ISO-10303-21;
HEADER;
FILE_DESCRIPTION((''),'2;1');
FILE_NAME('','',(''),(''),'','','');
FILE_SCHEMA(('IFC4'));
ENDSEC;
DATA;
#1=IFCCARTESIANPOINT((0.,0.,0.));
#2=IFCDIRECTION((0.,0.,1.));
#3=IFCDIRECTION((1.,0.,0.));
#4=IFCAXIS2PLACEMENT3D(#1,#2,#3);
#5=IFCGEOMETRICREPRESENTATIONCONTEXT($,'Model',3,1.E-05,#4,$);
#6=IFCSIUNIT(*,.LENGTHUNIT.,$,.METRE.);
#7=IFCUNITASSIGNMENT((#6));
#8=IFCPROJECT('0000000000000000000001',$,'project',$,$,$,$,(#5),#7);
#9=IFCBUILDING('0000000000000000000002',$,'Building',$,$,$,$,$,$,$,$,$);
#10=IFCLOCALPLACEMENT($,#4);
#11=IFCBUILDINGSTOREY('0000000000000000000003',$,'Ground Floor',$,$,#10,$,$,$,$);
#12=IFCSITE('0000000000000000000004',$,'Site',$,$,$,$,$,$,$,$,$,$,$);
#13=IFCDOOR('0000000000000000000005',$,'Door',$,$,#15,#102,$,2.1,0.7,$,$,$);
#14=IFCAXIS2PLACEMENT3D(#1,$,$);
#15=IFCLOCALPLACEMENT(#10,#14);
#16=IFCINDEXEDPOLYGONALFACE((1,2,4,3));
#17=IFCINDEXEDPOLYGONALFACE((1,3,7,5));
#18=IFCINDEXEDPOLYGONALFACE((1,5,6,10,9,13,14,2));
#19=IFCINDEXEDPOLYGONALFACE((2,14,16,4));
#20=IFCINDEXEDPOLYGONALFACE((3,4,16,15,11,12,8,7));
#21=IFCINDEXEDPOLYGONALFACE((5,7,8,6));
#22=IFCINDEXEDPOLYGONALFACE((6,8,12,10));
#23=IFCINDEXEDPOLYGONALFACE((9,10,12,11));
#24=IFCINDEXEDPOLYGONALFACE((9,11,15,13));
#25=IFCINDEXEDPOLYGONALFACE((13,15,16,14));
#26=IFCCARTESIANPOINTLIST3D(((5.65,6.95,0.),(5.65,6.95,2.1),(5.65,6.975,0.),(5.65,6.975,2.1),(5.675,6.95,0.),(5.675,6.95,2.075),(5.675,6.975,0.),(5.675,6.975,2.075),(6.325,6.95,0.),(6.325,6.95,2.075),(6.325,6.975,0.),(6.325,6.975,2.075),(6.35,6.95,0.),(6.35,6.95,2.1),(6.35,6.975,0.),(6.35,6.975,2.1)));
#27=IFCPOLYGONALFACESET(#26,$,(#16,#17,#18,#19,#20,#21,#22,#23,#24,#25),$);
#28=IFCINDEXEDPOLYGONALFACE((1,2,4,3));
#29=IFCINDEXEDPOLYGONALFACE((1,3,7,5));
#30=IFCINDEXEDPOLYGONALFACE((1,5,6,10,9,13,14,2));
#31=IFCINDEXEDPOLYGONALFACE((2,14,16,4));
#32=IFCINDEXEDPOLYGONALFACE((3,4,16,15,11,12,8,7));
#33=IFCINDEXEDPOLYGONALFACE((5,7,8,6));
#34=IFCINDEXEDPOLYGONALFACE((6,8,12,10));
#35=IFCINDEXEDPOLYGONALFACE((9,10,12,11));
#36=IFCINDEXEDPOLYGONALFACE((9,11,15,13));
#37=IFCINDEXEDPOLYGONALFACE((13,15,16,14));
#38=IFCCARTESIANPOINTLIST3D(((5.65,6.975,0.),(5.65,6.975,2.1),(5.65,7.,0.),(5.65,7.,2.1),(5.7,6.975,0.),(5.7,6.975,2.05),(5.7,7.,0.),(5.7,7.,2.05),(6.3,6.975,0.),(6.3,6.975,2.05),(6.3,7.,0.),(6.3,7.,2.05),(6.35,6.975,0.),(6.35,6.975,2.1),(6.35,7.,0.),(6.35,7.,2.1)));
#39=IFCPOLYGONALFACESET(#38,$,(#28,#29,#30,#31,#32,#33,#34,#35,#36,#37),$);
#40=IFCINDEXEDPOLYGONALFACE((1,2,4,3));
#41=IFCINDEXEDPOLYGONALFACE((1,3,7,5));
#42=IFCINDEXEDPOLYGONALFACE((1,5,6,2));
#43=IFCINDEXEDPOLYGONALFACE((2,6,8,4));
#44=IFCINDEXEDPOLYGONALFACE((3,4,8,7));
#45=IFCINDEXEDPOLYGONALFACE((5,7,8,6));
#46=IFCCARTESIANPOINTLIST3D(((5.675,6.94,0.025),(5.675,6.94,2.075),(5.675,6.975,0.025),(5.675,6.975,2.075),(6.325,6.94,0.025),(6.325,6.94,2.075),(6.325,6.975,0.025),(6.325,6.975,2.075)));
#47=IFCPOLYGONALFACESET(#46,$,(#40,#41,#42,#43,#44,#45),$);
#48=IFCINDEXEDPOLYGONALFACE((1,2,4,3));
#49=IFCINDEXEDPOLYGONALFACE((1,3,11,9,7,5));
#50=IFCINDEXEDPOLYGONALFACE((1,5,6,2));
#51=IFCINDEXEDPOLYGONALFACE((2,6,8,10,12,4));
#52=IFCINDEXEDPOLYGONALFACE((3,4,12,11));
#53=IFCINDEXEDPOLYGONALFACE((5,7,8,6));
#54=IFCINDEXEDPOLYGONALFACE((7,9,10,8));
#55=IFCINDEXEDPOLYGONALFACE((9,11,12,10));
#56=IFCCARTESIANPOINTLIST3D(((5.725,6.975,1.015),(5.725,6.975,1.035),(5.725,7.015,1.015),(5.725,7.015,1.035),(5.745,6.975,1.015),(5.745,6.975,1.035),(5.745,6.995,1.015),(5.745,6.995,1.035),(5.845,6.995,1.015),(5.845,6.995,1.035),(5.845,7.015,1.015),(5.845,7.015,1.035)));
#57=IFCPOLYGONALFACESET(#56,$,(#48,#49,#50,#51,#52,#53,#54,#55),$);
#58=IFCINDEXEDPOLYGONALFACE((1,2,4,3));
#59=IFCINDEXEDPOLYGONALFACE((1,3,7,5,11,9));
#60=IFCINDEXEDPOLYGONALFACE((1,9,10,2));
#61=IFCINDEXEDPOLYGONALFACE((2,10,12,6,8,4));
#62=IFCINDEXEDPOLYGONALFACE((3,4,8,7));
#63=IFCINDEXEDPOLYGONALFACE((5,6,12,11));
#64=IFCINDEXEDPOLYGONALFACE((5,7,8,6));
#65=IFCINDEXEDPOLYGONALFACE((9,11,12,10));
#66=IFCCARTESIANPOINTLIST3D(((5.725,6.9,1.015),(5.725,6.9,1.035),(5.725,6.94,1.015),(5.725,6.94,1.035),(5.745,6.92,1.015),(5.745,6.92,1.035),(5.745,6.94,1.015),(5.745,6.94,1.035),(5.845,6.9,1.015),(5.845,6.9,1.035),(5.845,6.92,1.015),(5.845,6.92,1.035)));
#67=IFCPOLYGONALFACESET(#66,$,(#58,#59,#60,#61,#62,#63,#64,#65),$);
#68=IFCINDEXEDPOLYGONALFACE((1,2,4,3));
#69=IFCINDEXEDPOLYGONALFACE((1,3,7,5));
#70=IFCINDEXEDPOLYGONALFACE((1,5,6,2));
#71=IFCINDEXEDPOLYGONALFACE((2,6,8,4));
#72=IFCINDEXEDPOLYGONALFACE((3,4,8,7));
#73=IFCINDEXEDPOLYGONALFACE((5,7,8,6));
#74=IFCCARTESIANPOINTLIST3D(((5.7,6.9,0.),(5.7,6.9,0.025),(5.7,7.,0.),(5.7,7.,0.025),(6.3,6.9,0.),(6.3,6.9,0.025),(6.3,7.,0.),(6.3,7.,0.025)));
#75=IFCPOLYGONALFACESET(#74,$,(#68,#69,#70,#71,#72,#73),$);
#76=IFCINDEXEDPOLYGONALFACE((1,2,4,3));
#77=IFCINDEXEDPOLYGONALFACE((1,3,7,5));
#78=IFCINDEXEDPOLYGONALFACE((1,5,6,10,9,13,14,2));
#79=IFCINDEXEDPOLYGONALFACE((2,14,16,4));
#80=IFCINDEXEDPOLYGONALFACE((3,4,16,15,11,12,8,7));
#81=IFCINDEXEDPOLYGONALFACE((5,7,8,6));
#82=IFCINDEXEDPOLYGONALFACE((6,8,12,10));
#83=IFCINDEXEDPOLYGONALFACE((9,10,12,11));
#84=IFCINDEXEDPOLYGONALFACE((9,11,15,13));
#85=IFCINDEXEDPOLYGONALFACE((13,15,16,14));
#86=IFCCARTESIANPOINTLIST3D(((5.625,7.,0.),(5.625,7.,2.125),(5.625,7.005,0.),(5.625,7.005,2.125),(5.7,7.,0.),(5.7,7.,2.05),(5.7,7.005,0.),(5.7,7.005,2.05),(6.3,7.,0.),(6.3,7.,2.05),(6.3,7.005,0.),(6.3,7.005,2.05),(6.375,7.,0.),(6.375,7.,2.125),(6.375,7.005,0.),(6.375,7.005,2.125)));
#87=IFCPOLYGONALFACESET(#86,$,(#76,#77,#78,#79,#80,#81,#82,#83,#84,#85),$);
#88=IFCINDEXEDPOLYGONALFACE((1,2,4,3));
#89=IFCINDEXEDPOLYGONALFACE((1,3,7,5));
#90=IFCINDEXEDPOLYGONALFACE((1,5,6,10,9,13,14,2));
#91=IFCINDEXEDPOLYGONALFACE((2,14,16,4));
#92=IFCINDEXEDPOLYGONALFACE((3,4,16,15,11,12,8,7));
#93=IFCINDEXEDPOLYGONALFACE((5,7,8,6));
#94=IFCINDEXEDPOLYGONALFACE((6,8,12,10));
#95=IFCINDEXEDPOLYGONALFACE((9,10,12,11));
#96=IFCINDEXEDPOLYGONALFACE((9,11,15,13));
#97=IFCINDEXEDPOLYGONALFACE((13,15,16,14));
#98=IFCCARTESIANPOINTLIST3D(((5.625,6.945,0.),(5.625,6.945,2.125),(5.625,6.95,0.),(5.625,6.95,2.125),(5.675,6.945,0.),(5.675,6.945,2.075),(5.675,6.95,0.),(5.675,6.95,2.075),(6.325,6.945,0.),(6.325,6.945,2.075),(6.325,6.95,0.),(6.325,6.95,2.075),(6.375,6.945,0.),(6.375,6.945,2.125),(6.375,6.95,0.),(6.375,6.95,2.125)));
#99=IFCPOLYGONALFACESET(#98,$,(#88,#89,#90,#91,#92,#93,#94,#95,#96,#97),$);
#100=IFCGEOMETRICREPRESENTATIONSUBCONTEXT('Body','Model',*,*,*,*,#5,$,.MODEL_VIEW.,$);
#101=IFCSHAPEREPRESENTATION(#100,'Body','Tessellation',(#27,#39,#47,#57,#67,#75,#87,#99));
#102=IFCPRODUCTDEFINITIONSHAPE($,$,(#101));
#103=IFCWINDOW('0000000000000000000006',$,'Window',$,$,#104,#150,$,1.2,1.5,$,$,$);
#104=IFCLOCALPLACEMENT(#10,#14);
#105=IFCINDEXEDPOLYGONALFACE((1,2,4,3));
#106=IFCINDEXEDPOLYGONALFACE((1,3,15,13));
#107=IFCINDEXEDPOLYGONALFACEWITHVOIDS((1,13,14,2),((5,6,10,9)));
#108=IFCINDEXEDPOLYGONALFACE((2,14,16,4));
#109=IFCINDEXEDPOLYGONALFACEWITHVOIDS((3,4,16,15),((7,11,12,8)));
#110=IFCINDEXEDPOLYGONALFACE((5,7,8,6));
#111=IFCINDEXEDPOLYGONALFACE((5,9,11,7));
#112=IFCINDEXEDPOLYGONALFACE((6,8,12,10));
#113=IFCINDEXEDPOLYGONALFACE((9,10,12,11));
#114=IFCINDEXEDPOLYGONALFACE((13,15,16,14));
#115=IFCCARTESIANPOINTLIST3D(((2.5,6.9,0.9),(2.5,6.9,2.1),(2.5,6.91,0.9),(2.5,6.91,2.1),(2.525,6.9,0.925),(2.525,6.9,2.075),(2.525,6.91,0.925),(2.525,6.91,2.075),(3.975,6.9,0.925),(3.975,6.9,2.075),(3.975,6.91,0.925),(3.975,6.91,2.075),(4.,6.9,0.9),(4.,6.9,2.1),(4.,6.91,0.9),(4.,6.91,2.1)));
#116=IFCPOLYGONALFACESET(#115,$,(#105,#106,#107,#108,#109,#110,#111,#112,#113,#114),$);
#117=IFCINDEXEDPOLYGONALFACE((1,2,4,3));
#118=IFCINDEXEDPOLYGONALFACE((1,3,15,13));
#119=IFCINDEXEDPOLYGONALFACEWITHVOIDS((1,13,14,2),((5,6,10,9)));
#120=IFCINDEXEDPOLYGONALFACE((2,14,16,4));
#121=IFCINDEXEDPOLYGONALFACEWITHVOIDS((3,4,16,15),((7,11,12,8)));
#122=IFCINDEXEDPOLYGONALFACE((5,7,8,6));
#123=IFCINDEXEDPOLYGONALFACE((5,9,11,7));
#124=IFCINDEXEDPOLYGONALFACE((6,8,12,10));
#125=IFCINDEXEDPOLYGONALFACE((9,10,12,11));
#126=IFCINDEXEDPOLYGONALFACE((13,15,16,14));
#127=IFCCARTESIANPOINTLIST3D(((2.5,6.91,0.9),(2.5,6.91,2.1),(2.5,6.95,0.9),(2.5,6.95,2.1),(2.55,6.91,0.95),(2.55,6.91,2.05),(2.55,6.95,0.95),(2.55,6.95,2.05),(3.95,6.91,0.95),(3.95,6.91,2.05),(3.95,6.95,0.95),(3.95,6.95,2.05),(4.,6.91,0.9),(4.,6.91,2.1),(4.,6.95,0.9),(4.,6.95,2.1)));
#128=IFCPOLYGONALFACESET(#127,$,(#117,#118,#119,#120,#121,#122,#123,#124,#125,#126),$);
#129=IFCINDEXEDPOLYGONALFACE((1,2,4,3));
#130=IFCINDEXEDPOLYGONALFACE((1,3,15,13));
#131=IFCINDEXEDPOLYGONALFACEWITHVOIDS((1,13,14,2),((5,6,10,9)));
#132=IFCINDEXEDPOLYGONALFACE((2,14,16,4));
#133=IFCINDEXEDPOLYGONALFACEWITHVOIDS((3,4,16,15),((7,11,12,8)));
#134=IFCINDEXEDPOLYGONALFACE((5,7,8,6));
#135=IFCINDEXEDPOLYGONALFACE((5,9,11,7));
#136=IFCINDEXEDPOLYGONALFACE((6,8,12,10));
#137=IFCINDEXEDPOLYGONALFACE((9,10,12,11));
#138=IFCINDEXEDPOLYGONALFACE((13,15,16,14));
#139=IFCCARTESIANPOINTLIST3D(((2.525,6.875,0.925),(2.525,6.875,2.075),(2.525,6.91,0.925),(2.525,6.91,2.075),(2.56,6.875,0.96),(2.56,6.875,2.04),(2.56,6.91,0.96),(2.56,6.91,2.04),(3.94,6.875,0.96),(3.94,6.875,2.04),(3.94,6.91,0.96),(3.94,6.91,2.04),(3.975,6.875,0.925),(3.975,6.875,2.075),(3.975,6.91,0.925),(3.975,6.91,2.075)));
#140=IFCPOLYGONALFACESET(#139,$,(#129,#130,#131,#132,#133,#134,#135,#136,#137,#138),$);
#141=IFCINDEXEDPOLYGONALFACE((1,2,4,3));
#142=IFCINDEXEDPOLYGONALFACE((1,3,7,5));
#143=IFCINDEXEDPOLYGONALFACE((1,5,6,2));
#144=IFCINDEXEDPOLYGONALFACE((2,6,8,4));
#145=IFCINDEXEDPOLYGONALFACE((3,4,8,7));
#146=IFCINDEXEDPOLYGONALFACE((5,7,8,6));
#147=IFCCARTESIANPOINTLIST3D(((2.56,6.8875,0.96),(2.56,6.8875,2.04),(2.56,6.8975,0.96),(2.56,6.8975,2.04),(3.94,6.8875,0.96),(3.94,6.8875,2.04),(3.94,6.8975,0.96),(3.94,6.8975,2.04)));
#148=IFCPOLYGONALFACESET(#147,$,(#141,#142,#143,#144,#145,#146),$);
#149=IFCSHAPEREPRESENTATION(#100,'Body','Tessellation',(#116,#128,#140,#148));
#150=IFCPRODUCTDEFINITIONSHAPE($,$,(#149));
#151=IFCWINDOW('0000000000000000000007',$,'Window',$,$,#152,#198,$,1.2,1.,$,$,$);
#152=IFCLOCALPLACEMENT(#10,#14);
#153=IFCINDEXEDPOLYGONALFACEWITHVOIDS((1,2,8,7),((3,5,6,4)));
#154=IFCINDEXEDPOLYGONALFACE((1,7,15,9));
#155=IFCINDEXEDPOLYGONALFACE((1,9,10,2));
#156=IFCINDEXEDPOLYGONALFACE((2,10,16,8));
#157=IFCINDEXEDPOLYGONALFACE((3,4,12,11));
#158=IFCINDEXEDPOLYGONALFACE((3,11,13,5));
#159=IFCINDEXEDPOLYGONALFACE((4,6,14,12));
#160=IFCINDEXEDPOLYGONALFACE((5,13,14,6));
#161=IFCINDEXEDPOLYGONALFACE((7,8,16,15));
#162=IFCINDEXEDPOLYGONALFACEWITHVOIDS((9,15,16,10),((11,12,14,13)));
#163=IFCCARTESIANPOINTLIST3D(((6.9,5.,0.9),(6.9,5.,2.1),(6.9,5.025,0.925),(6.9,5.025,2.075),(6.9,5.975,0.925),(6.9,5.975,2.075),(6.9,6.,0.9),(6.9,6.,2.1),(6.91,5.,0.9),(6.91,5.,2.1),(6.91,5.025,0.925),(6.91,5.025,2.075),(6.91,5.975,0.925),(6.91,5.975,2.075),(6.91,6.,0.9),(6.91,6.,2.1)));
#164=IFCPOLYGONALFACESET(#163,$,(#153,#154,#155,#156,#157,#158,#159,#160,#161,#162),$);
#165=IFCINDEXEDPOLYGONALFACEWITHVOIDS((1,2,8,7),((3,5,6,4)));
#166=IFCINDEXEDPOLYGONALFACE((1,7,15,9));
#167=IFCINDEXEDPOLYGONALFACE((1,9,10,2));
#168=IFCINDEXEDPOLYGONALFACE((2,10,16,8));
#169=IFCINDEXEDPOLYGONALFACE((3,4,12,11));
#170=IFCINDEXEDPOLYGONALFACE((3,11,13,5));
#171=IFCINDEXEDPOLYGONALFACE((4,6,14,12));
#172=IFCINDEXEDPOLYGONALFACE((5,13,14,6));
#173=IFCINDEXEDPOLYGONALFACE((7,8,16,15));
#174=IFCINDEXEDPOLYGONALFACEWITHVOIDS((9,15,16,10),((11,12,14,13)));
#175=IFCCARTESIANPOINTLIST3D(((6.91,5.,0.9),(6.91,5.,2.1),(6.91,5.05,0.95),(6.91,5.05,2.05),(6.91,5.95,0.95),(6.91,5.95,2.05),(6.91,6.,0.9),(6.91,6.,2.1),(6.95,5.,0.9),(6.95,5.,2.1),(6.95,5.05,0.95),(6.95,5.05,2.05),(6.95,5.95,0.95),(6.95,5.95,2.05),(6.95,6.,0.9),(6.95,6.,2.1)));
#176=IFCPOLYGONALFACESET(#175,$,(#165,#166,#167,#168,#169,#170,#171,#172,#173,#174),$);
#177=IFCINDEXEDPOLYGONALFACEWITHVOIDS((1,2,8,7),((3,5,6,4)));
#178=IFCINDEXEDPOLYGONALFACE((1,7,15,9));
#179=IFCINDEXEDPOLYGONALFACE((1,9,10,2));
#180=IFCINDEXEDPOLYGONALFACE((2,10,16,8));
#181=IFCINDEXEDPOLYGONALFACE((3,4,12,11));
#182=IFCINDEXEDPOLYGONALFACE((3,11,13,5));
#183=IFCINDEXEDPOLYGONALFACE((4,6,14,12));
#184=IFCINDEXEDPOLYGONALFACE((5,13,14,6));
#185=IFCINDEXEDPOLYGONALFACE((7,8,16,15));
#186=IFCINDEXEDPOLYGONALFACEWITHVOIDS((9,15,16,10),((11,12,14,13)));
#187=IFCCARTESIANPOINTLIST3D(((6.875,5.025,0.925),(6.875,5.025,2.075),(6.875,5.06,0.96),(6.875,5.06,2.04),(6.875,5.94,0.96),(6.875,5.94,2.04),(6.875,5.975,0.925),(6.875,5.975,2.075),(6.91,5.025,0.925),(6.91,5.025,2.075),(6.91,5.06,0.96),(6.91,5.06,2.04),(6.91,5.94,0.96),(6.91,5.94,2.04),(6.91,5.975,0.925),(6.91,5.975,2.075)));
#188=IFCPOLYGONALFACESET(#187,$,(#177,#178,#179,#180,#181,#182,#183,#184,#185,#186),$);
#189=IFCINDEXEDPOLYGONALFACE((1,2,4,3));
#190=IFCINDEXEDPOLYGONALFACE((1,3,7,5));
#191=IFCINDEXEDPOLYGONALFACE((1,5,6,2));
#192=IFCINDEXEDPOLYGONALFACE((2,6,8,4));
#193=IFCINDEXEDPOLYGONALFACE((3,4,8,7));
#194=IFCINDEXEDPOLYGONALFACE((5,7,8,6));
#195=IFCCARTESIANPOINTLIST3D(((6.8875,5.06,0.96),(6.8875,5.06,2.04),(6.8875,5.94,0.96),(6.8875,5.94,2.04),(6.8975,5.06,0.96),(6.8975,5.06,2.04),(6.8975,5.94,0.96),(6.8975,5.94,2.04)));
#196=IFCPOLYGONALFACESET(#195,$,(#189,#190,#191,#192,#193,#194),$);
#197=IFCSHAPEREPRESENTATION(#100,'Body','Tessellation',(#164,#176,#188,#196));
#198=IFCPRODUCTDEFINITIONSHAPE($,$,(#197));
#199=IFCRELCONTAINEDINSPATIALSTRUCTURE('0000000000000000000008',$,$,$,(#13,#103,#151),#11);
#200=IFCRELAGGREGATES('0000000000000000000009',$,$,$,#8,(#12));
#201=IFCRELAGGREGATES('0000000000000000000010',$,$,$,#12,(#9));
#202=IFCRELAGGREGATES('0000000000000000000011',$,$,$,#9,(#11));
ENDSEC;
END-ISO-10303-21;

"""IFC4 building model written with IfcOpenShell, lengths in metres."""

from ifc_helpers import new_model, si_unit, frame, origin_with_axes, place, context, subcontext, project, spatial, line, indexed_curve, outline, extrude, element, save


model = new_model("IFC4")

# Units and contexts
model_context = context("Model", 3, precision=1e-05, world=origin_with_axes())
body_context = subcontext(model_context, "Body", "Model", "MODEL_VIEW")
ifc_project = project(units=[si_unit("LENGTHUNIT", "METRE")], contexts=[model_context])

# Site, building, storey
site = spatial("IfcSite", under=ifc_project, Name="Site")
building = spatial("IfcBuilding", under=site, Name="Building")
storey_placement = place(None, origin_with_axes())
storey = spatial("IfcBuildingStorey", under=building, at=storey_placement, Name="Ground Floor")

# Door
door_1_placement = place(storey_placement, frame((6.35, 7.0, 0.0), z_axis=(0.0, 0.0, 1.0), x_axis=(-1.0, 0.0, 0.0)))
element("IfcDoor", 1, at=door_1_placement, inside=storey, Name="Door", OverallHeight=2.1, OverallWidth=0.7, context=body_context, shape_type="SweptSolid", body=[
    extrude(outline(indexed_curve([(0.0, 0.0), (0.0, 2.1), (0.7, 2.1), (0.7, 0.0), (0.675, 0.0), (0.675, 2.075), (0.025, 2.075), (0.025, 0.0)], segments=[line(1, 2, 3, 4, 5, 6, 7, 8, 1)])), frame((0.0, 0.025, 0.0), z_axis=(0.0, -1.0, 0.0), x_axis=(1.0, 0.0, 0.0)), (0.0, 0.0, -1.0), 0.025),
    extrude(outline(indexed_curve([(0.0, 0.0), (0.0, 2.1), (0.7, 2.1), (0.7, 0.0), (0.65, 0.0), (0.65, 2.05), (0.05, 2.05), (0.05, 0.0)], segments=[line(1, 2, 3, 4, 5, 6, 7, 8, 1)])), frame((0.0, 0.0, 0.0), z_axis=(0.0, -1.0, 0.0), x_axis=(1.0, 0.0, 0.0)), (0.0, 0.0, -1.0), 0.025),
    extrude(outline(indexed_curve([(0.0, 0.0), (0.65, 0.0), (0.65, 0.035), (0.0, 0.035)], segments=[line(1, 2, 3, 4, 1)])), frame((0.025, 0.025, 0.025), z_axis=(0.0, 0.0, 1.0), x_axis=(1.0, 0.0, 0.0)), (0.0, 0.0, 1.0), 2.05),
    extrude(outline(indexed_curve([(0.0, 0.0), (0.0, -0.04), (-0.12, -0.04), (-0.12, -0.02), (-0.02, -0.02), (-0.02, 0.0)], segments=[line(1, 2, 3, 4, 5, 6, 1)])), frame((0.625, 0.025, 1.015), z_axis=(0.0, 0.0, 1.0), x_axis=(1.0, 0.0, 0.0)), (0.0, 0.0, 1.0), 0.02),
    extrude(outline(indexed_curve([(0.0, 0.0), (0.0, 0.04), (-0.12, 0.04), (-0.12, 0.02), (-0.02, 0.02), (-0.02, 0.0)], segments=[line(1, 2, 3, 4, 5, 6, 1)])), frame((0.625, 0.06, 1.015), z_axis=(0.0, 0.0, 1.0), x_axis=(1.0, 0.0, 0.0)), (0.0, 0.0, 1.0), 0.02),
    extrude(outline(indexed_curve([(0.0, 0.0), (0.6, 0.0), (0.6, 0.1), (0.0, 0.1)], segments=[line(1, 2, 3, 4, 1)])), frame((0.05, 0.0, 0.0), z_axis=(0.0, 0.0, 1.0), x_axis=(1.0, 0.0, 0.0)), (0.0, 0.0, 1.0), 0.025),
    extrude(outline(indexed_curve([(0.0, 0.0), (0.0, 2.125), (0.75, 2.125), (0.75, 0.0), (0.675, 0.0), (0.675, 2.05), (0.075, 2.05), (0.075, 0.0)], segments=[line(1, 2, 3, 4, 5, 6, 7, 8, 1)])), frame((-0.025, -0.005, 0.0), z_axis=(0.0, -1.0, 0.0), x_axis=(1.0, 0.0, 0.0)), (0.0, 0.0, -1.0), 0.005),
    extrude(outline(indexed_curve([(0.0, 0.0), (0.0, 2.125), (0.75, 2.125), (0.75, 0.0), (0.7, 0.0), (0.7, 2.075), (0.05, 2.075), (0.05, 0.0)], segments=[line(1, 2, 3, 4, 5, 6, 7, 8, 1)])), frame((-0.025, 0.05, 0.0), z_axis=(0.0, -1.0, 0.0), x_axis=(1.0, 0.0, 0.0)), (0.0, 0.0, -1.0), 0.005),
])

# Windows
window_1_placement = place(storey_placement, frame((4.0, 7.0, 0.9), z_axis=(0.0, 0.0, 1.0), x_axis=(-1.0, 0.0, 0.0)))
element("IfcWindow", 2, at=window_1_placement, inside=storey, Name="Window", OverallHeight=1.2, OverallWidth=1.5, context=body_context, shape_type="SweptSolid", body=[
    extrude(outline(indexed_curve([(0.0, 0.0), (1.5, 0.0), (1.5, 1.2), (0.0, 1.2)], segments=[line(1, 2, 3, 4, 1)]), holes=[indexed_curve([(0.025, 0.025), (1.475, 0.025), (1.475, 1.175), (0.025, 1.175)], segments=[line(1, 2, 3, 4, 1)])]), frame((0.0, 0.09, 0.0), z_axis=(0.0, -1.0, 0.0), x_axis=(1.0, 0.0, 0.0)), (0.0, 0.0, -1.0), 0.01),
    extrude(outline(indexed_curve([(0.0, 0.0), (1.5, 0.0), (1.5, 1.2), (0.0, 1.2)], segments=[line(1, 2, 3, 4, 1)]), holes=[indexed_curve([(0.05, 0.05), (1.45, 0.05), (1.45, 1.15), (0.05, 1.15)], segments=[line(1, 2, 3, 4, 1)])]), frame((0.0, 0.05, 0.0), z_axis=(0.0, -1.0, 0.0), x_axis=(1.0, 0.0, 0.0)), (0.0, 0.0, -1.0), 0.04),
    extrude(outline(indexed_curve([(0.0, 0.0), (1.45, 0.0), (1.45, 1.15), (0.0, 1.15)], segments=[line(1, 2, 3, 4, 1)]), holes=[indexed_curve([(0.035, 0.035), (1.415, 0.035), (1.415, 1.115), (0.035, 1.115)], segments=[line(1, 2, 3, 4, 1)])]), frame((0.025, 0.09, 0.025), z_axis=(0.0, -1.0, 0.0), x_axis=(1.0, 0.0, 0.0)), (0.0, 0.0, -1.0), 0.035),
    extrude(outline(indexed_curve([(0.035, 0.035), (1.415, 0.035), (1.415, 1.115), (0.035, 1.115)], segments=[line(1, 2, 3, 4, 1)])), frame((0.025, 0.1025, 0.025), z_axis=(0.0, -1.0, 0.0), x_axis=(1.0, 0.0, 0.0)), (0.0, 0.0, -1.0), 0.01),
])
window_2_placement = place(storey_placement, frame((7.0, 5.0, 0.9), z_axis=(0.0, 0.0, 1.0), x_axis=(0.0, 1.0, 0.0)))
element("IfcWindow", 3, at=window_2_placement, inside=storey, Name="Window", OverallHeight=1.2, OverallWidth=1.0, context=body_context, shape_type="SweptSolid", body=[
    extrude(outline(indexed_curve([(0.0, 0.0), (1.0, 0.0), (1.0, 1.2), (0.0, 1.2)], segments=[line(1, 2, 3, 4, 1)]), holes=[indexed_curve([(0.025, 0.025), (0.975, 0.025), (0.975, 1.175), (0.025, 1.175)], segments=[line(1, 2, 3, 4, 1)])]), frame((0.0, 0.09, 0.0), z_axis=(0.0, -1.0, 0.0), x_axis=(1.0, 0.0, 0.0)), (0.0, 0.0, -1.0), 0.01),
    extrude(outline(indexed_curve([(0.0, 0.0), (1.0, 0.0), (1.0, 1.2), (0.0, 1.2)], segments=[line(1, 2, 3, 4, 1)]), holes=[indexed_curve([(0.05, 0.05), (0.95, 0.05), (0.95, 1.15), (0.05, 1.15)], segments=[line(1, 2, 3, 4, 1)])]), frame((0.0, 0.05, 0.0), z_axis=(0.0, -1.0, 0.0), x_axis=(1.0, 0.0, 0.0)), (0.0, 0.0, -1.0), 0.04),
    extrude(outline(indexed_curve([(0.0, 0.0), (0.95, 0.0), (0.95, 1.15), (0.0, 1.15)], segments=[line(1, 2, 3, 4, 1)]), holes=[indexed_curve([(0.035, 0.035), (0.915, 0.035), (0.915, 1.115), (0.035, 1.115)], segments=[line(1, 2, 3, 4, 1)])]), frame((0.025, 0.09, 0.025), z_axis=(0.0, -1.0, 0.0), x_axis=(1.0, 0.0, 0.0)), (0.0, 0.0, -1.0), 0.035),
    extrude(outline(indexed_curve([(0.035, 0.035), (0.915, 0.035), (0.915, 1.115), (0.035, 1.115)], segments=[line(1, 2, 3, 4, 1)])), frame((0.025, 0.1025, 0.025), z_axis=(0.0, -1.0, 0.0), x_axis=(1.0, 0.0, 0.0)), (0.0, 0.0, -1.0), 0.01),
])

save(model, "model.ifc")
